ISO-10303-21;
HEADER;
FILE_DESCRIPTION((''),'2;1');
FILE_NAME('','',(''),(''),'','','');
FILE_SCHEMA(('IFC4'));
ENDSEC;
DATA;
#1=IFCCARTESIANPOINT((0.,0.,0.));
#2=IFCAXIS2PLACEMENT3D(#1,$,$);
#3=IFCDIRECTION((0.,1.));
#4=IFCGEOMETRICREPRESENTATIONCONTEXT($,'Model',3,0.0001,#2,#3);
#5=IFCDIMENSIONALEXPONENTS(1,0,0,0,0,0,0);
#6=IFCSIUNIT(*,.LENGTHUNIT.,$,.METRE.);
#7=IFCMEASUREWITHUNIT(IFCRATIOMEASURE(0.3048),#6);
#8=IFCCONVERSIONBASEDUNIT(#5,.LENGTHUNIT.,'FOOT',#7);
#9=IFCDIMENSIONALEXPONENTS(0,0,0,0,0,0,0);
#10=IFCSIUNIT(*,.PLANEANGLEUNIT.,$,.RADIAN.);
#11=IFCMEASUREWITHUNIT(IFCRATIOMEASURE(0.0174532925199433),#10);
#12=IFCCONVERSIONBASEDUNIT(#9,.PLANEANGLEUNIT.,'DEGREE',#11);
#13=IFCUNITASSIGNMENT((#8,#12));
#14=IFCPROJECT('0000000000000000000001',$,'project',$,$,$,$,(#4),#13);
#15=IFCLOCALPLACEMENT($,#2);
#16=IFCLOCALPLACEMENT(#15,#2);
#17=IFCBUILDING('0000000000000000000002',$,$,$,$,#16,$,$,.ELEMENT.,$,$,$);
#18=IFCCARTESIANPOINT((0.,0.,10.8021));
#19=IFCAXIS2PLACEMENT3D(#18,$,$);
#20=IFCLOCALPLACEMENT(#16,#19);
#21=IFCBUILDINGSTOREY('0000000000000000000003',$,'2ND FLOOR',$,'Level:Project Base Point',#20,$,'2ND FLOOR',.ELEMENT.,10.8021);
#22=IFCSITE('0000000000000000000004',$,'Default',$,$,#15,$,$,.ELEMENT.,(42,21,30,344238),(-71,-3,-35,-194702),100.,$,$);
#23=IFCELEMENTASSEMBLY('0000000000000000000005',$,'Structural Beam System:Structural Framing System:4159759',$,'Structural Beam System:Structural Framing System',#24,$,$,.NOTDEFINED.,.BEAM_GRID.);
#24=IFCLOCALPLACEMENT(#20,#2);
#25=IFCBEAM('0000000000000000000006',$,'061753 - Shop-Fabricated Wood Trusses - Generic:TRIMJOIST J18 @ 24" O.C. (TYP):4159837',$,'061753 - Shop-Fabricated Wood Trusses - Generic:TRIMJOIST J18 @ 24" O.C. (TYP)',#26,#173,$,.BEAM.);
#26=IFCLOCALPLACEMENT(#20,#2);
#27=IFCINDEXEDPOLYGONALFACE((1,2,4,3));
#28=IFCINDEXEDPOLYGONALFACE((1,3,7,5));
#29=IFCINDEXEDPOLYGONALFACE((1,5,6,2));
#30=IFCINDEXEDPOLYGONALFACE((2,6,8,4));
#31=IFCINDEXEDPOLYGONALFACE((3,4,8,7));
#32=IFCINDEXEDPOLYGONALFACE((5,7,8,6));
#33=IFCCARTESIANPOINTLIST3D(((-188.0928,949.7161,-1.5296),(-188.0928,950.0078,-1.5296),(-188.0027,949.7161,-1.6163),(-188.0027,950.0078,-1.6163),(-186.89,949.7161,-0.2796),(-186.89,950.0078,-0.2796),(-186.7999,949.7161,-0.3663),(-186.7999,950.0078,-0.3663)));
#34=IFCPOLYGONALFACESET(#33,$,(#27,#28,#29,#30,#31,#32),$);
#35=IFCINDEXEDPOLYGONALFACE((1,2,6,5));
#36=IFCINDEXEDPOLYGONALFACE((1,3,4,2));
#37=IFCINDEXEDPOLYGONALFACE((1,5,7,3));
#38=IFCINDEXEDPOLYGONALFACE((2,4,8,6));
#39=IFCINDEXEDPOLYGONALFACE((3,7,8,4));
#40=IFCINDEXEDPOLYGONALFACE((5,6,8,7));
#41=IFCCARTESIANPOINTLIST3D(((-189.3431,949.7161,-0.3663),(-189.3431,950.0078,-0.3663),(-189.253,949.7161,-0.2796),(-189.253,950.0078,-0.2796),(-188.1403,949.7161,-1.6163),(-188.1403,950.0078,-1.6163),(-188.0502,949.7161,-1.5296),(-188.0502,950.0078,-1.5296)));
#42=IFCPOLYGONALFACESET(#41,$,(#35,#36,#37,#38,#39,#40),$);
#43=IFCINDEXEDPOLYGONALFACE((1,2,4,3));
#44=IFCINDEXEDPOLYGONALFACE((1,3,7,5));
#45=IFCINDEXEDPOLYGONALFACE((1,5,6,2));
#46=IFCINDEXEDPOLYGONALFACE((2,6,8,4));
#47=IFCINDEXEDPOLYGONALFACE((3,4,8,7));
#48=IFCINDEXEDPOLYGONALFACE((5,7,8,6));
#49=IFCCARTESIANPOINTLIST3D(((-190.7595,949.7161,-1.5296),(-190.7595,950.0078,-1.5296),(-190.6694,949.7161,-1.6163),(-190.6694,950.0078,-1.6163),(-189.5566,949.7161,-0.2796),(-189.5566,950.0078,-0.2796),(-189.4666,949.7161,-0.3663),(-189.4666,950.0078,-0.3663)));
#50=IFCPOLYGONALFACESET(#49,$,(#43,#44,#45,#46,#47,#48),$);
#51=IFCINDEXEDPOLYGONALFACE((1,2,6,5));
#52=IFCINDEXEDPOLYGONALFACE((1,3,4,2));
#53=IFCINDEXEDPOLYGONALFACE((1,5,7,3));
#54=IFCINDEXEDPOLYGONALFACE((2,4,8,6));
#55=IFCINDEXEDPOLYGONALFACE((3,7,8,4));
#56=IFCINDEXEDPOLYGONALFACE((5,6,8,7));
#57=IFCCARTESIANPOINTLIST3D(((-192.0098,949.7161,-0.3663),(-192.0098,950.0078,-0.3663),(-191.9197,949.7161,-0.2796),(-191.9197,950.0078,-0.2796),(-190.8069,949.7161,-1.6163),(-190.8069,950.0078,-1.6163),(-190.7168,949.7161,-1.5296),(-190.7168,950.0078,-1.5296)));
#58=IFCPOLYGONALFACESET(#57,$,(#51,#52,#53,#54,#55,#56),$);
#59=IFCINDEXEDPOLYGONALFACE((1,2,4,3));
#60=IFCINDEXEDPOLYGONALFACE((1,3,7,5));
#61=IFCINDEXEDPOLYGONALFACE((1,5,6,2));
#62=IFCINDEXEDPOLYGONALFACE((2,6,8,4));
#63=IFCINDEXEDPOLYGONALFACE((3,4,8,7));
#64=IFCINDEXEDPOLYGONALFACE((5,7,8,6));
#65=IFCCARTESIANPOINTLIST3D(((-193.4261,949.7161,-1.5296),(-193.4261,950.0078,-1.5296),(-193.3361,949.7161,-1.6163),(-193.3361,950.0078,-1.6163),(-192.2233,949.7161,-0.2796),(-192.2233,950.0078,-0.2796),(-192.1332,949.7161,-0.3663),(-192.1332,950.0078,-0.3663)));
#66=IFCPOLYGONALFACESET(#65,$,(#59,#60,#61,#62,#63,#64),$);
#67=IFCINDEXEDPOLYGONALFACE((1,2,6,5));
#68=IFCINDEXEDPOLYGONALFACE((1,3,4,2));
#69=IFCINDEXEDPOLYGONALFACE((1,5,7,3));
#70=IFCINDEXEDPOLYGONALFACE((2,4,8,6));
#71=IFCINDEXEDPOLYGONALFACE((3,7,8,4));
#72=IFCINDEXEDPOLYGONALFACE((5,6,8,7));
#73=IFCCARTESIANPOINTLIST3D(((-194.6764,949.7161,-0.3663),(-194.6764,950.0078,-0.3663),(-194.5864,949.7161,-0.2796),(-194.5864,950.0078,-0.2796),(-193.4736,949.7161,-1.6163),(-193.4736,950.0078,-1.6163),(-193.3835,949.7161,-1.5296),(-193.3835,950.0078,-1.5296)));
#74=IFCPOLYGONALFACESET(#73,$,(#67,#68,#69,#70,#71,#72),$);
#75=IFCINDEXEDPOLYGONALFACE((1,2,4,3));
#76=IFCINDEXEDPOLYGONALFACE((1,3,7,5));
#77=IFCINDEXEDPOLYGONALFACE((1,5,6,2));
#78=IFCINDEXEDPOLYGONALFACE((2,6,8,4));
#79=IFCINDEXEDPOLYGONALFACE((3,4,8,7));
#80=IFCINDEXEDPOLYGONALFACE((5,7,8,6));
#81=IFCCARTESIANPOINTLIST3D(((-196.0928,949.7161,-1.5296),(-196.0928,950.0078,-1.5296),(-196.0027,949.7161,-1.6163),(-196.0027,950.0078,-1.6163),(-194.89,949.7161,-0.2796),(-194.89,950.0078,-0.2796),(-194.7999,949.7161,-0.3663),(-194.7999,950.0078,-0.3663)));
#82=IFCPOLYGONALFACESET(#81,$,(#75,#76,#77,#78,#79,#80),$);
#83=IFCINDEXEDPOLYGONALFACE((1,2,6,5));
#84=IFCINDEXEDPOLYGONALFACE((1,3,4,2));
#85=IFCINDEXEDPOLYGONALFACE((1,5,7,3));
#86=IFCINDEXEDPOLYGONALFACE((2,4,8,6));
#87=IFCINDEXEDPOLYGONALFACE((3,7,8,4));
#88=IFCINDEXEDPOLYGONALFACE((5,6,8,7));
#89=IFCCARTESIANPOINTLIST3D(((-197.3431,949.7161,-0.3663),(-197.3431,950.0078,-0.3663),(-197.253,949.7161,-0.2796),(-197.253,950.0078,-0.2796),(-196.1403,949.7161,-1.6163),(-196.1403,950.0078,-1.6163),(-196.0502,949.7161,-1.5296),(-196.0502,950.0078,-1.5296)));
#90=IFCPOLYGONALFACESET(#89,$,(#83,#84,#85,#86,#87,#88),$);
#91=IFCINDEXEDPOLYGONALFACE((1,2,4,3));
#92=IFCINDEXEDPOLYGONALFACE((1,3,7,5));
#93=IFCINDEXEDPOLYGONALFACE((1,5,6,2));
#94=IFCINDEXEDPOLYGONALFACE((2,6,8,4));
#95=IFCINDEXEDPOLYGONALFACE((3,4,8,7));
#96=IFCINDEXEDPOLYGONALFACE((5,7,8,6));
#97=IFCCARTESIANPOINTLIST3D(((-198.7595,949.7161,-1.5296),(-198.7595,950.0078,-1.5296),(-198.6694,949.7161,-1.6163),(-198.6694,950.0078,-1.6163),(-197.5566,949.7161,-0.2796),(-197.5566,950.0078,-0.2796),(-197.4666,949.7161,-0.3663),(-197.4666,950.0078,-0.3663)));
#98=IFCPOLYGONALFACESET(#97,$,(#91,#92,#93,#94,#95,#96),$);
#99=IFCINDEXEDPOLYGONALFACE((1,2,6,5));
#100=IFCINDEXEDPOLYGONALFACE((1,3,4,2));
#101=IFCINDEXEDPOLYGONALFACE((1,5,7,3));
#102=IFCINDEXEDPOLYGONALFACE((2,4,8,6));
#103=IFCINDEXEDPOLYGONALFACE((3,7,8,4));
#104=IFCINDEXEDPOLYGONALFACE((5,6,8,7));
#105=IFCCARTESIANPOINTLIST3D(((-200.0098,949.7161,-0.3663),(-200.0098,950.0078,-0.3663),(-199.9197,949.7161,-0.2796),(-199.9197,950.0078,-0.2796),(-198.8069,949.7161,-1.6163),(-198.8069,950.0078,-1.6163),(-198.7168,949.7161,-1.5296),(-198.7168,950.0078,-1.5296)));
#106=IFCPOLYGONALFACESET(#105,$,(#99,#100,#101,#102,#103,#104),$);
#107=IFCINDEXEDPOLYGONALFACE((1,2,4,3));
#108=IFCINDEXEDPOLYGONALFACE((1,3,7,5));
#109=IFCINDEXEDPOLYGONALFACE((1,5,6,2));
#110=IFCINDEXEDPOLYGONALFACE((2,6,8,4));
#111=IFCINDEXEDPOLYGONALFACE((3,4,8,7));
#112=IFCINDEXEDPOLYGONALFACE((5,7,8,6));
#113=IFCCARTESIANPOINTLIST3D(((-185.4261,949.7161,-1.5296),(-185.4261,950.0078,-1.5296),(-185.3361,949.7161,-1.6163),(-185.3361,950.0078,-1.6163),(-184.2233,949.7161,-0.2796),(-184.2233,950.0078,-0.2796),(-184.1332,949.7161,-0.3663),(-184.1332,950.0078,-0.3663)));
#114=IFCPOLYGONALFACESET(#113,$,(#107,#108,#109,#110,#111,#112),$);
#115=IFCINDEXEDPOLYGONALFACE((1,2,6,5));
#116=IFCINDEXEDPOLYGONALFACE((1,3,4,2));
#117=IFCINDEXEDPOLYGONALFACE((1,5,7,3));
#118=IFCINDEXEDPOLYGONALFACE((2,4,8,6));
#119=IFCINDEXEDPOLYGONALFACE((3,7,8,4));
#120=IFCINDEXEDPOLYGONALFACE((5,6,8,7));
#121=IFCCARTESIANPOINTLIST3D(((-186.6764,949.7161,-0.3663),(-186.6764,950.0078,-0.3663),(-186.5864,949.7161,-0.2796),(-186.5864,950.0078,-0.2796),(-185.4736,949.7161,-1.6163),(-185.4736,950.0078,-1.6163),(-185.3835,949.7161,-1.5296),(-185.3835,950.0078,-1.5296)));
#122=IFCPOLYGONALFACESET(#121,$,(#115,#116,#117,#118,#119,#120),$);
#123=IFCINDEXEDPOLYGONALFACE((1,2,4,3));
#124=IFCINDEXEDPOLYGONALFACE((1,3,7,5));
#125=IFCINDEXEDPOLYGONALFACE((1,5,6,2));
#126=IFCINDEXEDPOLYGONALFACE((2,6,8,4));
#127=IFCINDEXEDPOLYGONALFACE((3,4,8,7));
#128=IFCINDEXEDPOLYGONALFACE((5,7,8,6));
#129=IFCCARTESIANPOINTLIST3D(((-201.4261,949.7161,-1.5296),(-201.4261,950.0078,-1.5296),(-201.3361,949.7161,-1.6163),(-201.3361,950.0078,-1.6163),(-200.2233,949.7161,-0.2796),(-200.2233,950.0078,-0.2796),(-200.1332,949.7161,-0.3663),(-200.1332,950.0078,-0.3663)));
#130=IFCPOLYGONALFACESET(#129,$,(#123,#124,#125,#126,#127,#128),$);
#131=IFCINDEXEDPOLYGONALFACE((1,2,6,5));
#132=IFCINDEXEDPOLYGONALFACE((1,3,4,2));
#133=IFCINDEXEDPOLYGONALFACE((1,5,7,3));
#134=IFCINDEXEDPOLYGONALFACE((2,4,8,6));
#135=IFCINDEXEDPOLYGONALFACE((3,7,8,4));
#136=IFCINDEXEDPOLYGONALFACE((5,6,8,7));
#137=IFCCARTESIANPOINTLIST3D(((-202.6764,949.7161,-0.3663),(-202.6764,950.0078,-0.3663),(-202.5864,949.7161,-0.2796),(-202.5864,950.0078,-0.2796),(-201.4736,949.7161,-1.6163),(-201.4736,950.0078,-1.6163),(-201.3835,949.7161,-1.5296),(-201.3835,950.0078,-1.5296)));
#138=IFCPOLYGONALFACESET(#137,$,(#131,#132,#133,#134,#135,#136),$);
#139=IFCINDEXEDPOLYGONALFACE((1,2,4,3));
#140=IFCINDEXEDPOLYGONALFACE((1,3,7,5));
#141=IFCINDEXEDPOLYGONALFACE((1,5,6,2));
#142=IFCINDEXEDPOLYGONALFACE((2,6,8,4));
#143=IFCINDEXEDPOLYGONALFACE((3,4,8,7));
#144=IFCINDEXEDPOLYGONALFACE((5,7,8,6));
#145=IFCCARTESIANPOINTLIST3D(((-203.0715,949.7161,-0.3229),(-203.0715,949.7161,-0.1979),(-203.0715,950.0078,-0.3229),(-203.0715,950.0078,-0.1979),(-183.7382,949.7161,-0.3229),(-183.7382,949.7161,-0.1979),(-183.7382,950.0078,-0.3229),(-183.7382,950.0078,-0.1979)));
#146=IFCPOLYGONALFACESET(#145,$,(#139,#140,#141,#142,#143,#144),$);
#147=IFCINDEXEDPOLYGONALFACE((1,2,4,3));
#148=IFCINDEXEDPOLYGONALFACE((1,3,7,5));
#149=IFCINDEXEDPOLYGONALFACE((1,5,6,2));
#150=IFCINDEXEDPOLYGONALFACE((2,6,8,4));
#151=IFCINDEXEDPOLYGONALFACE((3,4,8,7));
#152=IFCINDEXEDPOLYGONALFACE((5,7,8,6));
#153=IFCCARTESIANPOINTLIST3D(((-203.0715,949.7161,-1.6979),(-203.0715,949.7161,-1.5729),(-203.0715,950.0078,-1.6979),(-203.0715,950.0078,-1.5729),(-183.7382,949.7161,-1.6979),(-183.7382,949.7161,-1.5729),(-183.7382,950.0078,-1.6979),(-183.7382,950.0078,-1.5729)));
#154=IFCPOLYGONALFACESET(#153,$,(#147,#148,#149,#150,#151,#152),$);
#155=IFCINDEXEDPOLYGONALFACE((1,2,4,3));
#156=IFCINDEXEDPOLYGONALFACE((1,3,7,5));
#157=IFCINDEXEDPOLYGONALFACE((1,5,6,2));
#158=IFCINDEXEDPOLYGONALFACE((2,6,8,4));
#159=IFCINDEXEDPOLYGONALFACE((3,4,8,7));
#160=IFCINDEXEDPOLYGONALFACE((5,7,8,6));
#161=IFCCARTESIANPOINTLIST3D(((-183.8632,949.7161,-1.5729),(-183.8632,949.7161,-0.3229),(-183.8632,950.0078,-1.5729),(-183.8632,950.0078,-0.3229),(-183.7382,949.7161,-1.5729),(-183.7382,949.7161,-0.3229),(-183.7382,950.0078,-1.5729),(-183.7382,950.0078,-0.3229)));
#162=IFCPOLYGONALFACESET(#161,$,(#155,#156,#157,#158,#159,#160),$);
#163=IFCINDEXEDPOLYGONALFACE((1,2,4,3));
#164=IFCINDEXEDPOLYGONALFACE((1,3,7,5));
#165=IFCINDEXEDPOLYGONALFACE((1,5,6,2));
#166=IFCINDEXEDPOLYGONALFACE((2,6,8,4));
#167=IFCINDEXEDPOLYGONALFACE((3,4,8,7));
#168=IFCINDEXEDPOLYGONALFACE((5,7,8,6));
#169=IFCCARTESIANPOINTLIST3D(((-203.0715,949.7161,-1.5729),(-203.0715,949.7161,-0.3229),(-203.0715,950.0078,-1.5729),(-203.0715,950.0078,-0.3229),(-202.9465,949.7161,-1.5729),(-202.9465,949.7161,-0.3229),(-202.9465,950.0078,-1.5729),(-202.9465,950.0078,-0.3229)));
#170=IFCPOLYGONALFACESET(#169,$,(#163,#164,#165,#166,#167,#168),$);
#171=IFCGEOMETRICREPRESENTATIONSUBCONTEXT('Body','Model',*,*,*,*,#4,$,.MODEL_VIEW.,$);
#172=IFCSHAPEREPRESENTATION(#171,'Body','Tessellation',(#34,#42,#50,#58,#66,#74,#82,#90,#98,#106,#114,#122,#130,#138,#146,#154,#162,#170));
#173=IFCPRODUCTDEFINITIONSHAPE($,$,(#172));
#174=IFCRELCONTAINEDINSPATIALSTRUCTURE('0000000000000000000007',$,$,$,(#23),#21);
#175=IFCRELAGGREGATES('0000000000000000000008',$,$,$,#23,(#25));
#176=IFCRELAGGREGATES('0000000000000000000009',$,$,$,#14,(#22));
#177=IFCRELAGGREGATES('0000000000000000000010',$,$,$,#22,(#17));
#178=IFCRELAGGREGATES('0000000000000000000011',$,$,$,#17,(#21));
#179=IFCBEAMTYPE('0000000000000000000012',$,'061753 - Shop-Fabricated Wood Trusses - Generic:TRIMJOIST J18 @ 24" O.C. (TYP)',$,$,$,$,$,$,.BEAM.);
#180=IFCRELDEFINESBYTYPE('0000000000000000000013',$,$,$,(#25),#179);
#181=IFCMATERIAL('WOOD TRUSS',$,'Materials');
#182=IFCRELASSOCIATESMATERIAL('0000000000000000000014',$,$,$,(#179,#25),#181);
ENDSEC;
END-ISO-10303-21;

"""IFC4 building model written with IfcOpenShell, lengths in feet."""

from ifc_helpers import new_model, entity, si_unit, converted_unit, direction, frame, frame_2d, origin, origin_2d_with_axis, place, context, subcontext, project, spatial, rectangle, extrude, source, transform, mapped, material, material_profile, profile_set, profile_usage, type_object, type_shapes, element, aggregate, save


model = new_model("IFC4")

# Units and contexts
model_context = context("Model", 3, precision=0.0001, world=origin(), true_north=direction((0.0, 1.0)))
body_context = subcontext(model_context, "Body", "Model", "MODEL_VIEW")
ifc_project = project(units=[converted_unit("LENGTHUNIT", "FOOT", entity("IfcRatioMeasure", 0.3048), si_unit("LENGTHUNIT", "METRE"), dimensions=[1, 0, 0, 0, 0, 0, 0]), converted_unit("PLANEANGLEUNIT", "DEGREE", entity("IfcRatioMeasure", 0.0174532925199433), si_unit("PLANEANGLEUNIT", "RADIAN"), dimensions=[0, 0, 0, 0, 0, 0, 0])], contexts=[model_context])

# Site, building, storey
site_placement = place(None, origin())
site = spatial("IfcSite", under=ifc_project, at=site_placement, Name="Default", CompositionType="ELEMENT", RefLatitude=(42, 21, 30, 344238), RefLongitude=(-71, -3, -35, -194702), RefElevation=100.0)
building_placement = place(site_placement, origin())
building = spatial("IfcBuilding", under=site, at=building_placement, CompositionType="ELEMENT")
storey_placement = place(building_placement, frame((0.0, 0.0, 10.8021)))
storey = spatial("IfcBuildingStorey", under=building, at=storey_placement, Name="2ND FLOOR", ObjectType="Level:Project Base Point", LongName="2ND FLOOR", CompositionType="ELEMENT", Elevation=10.8021)

# Element assembly, beam
ifc_material_1 = material(Name="WOOD TRUSS", Category="Materials")
ifc_material_profile_1 = material_profile(ifc_material_1, rectangle(XDim=1.7347, YDim=0.125, at=frame_2d((0.0, 0.0), x_axis=(1.0, 0.0))), Name="TRIMJOIST J18 @ 24\" O.C. (TYP)")
ifc_material_profile_2 = material_profile(ifc_material_1, rectangle(XDim=1.7347, YDim=0.125, at=frame_2d((0.0, 0.0), x_axis=(1.0, 0.0))), Name="TRIMJOIST J18 @ 24\" O.C. (TYP)")
ifc_material_profile_3 = material_profile(ifc_material_1, rectangle(XDim=1.7347, YDim=0.125, at=frame_2d((0.0, 0.0), x_axis=(1.0, 0.0))), Name="TRIMJOIST J18 @ 24\" O.C. (TYP)")
ifc_material_profile_4 = material_profile(ifc_material_1, rectangle(XDim=1.7347, YDim=0.125, at=frame_2d((0.0, 0.0), x_axis=(1.0, 0.0))), Name="TRIMJOIST J18 @ 24\" O.C. (TYP)")
ifc_material_profile_5 = material_profile(ifc_material_1, rectangle(XDim=1.7347, YDim=0.125, at=frame_2d((0.0, 0.0), x_axis=(1.0, 0.0))), Name="TRIMJOIST J18 @ 24\" O.C. (TYP)")
ifc_material_profile_6 = material_profile(ifc_material_1, rectangle(XDim=1.7347, YDim=0.125, at=frame_2d((0.0, 0.0), x_axis=(1.0, 0.0))), Name="TRIMJOIST J18 @ 24\" O.C. (TYP)")
ifc_material_profile_7 = material_profile(ifc_material_1, rectangle(XDim=1.7347, YDim=0.125, at=frame_2d((0.0, 0.0), x_axis=(1.0, 0.0))), Name="TRIMJOIST J18 @ 24\" O.C. (TYP)")
ifc_material_profile_8 = material_profile(ifc_material_1, rectangle(XDim=1.7347, YDim=0.125, at=frame_2d((0.0, 0.0), x_axis=(1.0, 0.0))), Name="TRIMJOIST J18 @ 24\" O.C. (TYP)")
ifc_material_profile_9 = material_profile(ifc_material_1, rectangle(XDim=1.7347, YDim=0.125, at=frame_2d((0.0, 0.0), x_axis=(1.0, 0.0))), Name="TRIMJOIST J18 @ 24\" O.C. (TYP)")
ifc_material_profile_10 = material_profile(ifc_material_1, rectangle(XDim=1.7347, YDim=0.125, at=origin_2d_with_axis()), Name="TRIMJOIST J18 @ 24\" O.C. (TYP)")
ifc_material_profile_11 = material_profile(ifc_material_1, rectangle(XDim=0.125, YDim=0.2917, at=origin_2d_with_axis()), Name="TRIMJOIST J18 @ 24\" O.C. (TYP)")
ifc_material_profile_12 = material_profile(ifc_material_1, rectangle(XDim=0.125, YDim=0.2917, at=origin_2d_with_axis()), Name="TRIMJOIST J18 @ 24\" O.C. (TYP)")
ifc_material_profile_13 = material_profile(ifc_material_1, rectangle(XDim=1.25, YDim=0.2917, at=origin_2d_with_axis()), Name="TRIMJOIST J18 @ 24\" O.C. (TYP)")
ifc_material_profile_14 = material_profile(ifc_material_1, rectangle(XDim=1.25, YDim=0.2917, at=origin_2d_with_axis()), Name="TRIMJOIST J18 @ 24\" O.C. (TYP)")
ifc_profile_set_1 = profile_set([ifc_material_profile_1, ifc_material_profile_2, ifc_material_profile_3, ifc_material_profile_4, ifc_material_profile_5, ifc_material_profile_6, ifc_material_profile_7, ifc_material_profile_8, ifc_material_profile_9, ifc_material_profile_10, ifc_material_profile_11, ifc_material_profile_12, ifc_material_profile_13, ifc_material_profile_14], Name="TRIMJOIST J18 @ 24\" O.C. (TYP)")
beam_type_1 = type_object("IfcBeamType", Name="061753 - Shop-Fabricated Wood Trusses - Generic:TRIMJOIST J18 @ 24\" O.C. (TYP)", PredefinedType="BEAM", material=ifc_profile_set_1)
shared_shape_1 = source(origin(), body_context, "Body", "SweptSolid", [
    extrude(rectangle(XDim=1.7347, YDim=0.125, at=frame_2d((0.0, 0.0), x_axis=(1.0, 0.0))), frame((5.9585, -0.1458, 0.0), z_axis=(0.0, 1.0, 0.0), x_axis=(0.693383, 0.0, 0.720569)), (0.0, 0.0, 1.0), 0.2917),
    extrude(rectangle(XDim=1.7347, YDim=0.125, at=origin_2d_with_axis()), frame((4.7082, -0.1458, 0.0), z_axis=(0.0, 1.0, 0.0), x_axis=(0.693383, 0.0, -0.720569)), (0.0, 0.0, 1.0), 0.2917),
    extrude(rectangle(XDim=1.7347, YDim=0.125, at=frame_2d((0.0, 0.0), x_axis=(1.0, 0.0))), frame((3.2918, -0.1458, 0.0), z_axis=(0.0, 1.0, 0.0), x_axis=(0.693383, 0.0, 0.720569)), (0.0, 0.0, 1.0), 0.2917),
    extrude(rectangle(XDim=1.7347, YDim=0.125, at=frame_2d((0.0, 0.0), x_axis=(1.0, 0.0))), frame((2.0415, -0.1458, 0.0), z_axis=(0.0, 1.0, 0.0), x_axis=(0.693383, 0.0, -0.720569)), (0.0, 0.0, 1.0), 0.2917),
    extrude(rectangle(XDim=1.7347, YDim=0.125, at=frame_2d((0.0, 0.0), x_axis=(1.0, 0.0))), frame((0.6251, -0.1458, 0.0), z_axis=(0.0, 1.0, 0.0), x_axis=(0.693383, 0.0, 0.720569)), (0.0, 0.0, 1.0), 0.2917),
    extrude(rectangle(XDim=1.7347, YDim=0.125, at=frame_2d((0.0, 0.0), x_axis=(1.0, 0.0))), frame((-0.6251, -0.1458, 0.0), z_axis=(0.0, 1.0, 0.0), x_axis=(0.693383, 0.0, -0.720569)), (0.0, 0.0, 1.0), 0.2917),
    extrude(rectangle(XDim=1.7347, YDim=0.125, at=frame_2d((0.0, 0.0), x_axis=(1.0, 0.0))), frame((-2.0415, -0.1458, 0.0), z_axis=(0.0, 1.0, 0.0), x_axis=(0.693383, 0.0, 0.720569)), (0.0, 0.0, 1.0), 0.2917),
    extrude(rectangle(XDim=1.7347, YDim=0.125, at=origin_2d_with_axis()), frame((-3.2918, -0.1458, 0.0), z_axis=(0.0, 1.0, 0.0), x_axis=(0.693383, 0.0, -0.720569)), (0.0, 0.0, 1.0), 0.2917),
    extrude(rectangle(XDim=1.7347, YDim=0.125, at=frame_2d((0.0, 0.0), x_axis=(1.0, 0.0))), frame((-4.7082, -0.1458, 0.0), z_axis=(0.0, 1.0, 0.0), x_axis=(0.693383, 0.0, 0.720569)), (0.0, 0.0, 1.0), 0.2917),
    extrude(rectangle(XDim=1.7347, YDim=0.125, at=frame_2d((0.0, 0.0), x_axis=(1.0, 0.0))), frame((-5.9585, -0.1458, 0.0), z_axis=(0.0, 1.0, 0.0), x_axis=(0.693383, 0.0, -0.720569)), (0.0, 0.0, 1.0), 0.2917),
    extrude(rectangle(XDim=1.7347, YDim=0.125, at=frame_2d((0.0, 0.0), x_axis=(1.0, 0.0))), frame((8.6251, -0.1458, 0.0), z_axis=(0.0, 1.0, 0.0), x_axis=(0.693383, 0.0, 0.720569)), (0.0, 0.0, 1.0), 0.2917),
    extrude(rectangle(XDim=1.7347, YDim=0.125, at=origin_2d_with_axis()), frame((7.3749, -0.1458, 0.0), z_axis=(0.0, 1.0, 0.0), x_axis=(0.693383, 0.0, -0.720569)), (0.0, 0.0, 1.0), 0.2917),
    extrude(rectangle(XDim=1.7347, YDim=0.125, at=frame_2d((0.0, 0.0), x_axis=(1.0, 0.0))), frame((-7.3749, -0.1458, 0.0), z_axis=(0.0, 1.0, 0.0), x_axis=(0.693383, 0.0, 0.720569)), (0.0, 0.0, 1.0), 0.2917),
    extrude(rectangle(XDim=1.7347, YDim=0.125, at=origin_2d_with_axis()), frame((-8.6251, -0.1458, 0.0), z_axis=(0.0, 1.0, 0.0), x_axis=(0.693383, 0.0, -0.720569)), (0.0, 0.0, 1.0), 0.2917),
    extrude(rectangle(XDim=0.125, YDim=0.2917, at=origin_2d_with_axis()), frame((-9.6667, 0.0, 0.6875), z_axis=(1.0, 0.0, 0.0), x_axis=(0.0, 0.0, -1.0)), (0.0, 0.0, 1.0), 19.3333),
    extrude(rectangle(XDim=0.125, YDim=0.2917, at=origin_2d_with_axis()), frame((-9.6667, 0.0, -0.6875), z_axis=(1.0, 0.0, 0.0), x_axis=(0.0, 0.0, -1.0)), (0.0, 0.0, 1.0), 19.3333),
    extrude(rectangle(XDim=1.25, YDim=0.2917, at=origin_2d_with_axis()), frame((9.5417, 0.0, 0.0), z_axis=(1.0, 0.0, 0.0), x_axis=(0.0, 0.0, -1.0)), (0.0, 0.0, 1.0), 0.125),
    extrude(rectangle(XDim=1.25, YDim=0.2917, at=origin_2d_with_axis()), frame((-9.6667, 0.0, 0.0), z_axis=(1.0, 0.0, 0.0), x_axis=(0.0, 0.0, -1.0)), (0.0, 0.0, 1.0), 0.125),
])
type_shapes(beam_type_1, [shared_shape_1])
assembly_1_placement = place(storey_placement, origin())
assembly_1 = element("IfcElementAssembly", 1, at=assembly_1_placement, inside=storey, Name="Structural Beam System:Structural Framing System:4159759", ObjectType="Structural Beam System:Structural Framing System", AssemblyPlace="NOTDEFINED", PredefinedType="BEAM_GRID")
ifc_profile_usage_1 = profile_usage(ifc_profile_set_1, cardinal=8)
beam_1_placement = place(assembly_1_placement, frame((-193.4048, 949.8619, -0.9479)))
beam_1 = element("IfcBeam", 2, at=beam_1_placement, type_object=beam_type_1, material=ifc_profile_usage_1, Name="061753 - Shop-Fabricated Wood Trusses - Generic:TRIMJOIST J18 @ 24\" O.C. (TYP):4159837", ObjectType="061753 - Shop-Fabricated Wood Trusses - Generic:TRIMJOIST J18 @ 24\" O.C. (TYP)", PredefinedType="BEAM", context=body_context, shape_type="MappedRepresentation", body=[
    mapped(shared_shape_1, transform((0.0, 0.0, 0.0), scale=1.0)),
])

aggregate(assembly_1, [beam_1])

save(model, "model.ifc")
